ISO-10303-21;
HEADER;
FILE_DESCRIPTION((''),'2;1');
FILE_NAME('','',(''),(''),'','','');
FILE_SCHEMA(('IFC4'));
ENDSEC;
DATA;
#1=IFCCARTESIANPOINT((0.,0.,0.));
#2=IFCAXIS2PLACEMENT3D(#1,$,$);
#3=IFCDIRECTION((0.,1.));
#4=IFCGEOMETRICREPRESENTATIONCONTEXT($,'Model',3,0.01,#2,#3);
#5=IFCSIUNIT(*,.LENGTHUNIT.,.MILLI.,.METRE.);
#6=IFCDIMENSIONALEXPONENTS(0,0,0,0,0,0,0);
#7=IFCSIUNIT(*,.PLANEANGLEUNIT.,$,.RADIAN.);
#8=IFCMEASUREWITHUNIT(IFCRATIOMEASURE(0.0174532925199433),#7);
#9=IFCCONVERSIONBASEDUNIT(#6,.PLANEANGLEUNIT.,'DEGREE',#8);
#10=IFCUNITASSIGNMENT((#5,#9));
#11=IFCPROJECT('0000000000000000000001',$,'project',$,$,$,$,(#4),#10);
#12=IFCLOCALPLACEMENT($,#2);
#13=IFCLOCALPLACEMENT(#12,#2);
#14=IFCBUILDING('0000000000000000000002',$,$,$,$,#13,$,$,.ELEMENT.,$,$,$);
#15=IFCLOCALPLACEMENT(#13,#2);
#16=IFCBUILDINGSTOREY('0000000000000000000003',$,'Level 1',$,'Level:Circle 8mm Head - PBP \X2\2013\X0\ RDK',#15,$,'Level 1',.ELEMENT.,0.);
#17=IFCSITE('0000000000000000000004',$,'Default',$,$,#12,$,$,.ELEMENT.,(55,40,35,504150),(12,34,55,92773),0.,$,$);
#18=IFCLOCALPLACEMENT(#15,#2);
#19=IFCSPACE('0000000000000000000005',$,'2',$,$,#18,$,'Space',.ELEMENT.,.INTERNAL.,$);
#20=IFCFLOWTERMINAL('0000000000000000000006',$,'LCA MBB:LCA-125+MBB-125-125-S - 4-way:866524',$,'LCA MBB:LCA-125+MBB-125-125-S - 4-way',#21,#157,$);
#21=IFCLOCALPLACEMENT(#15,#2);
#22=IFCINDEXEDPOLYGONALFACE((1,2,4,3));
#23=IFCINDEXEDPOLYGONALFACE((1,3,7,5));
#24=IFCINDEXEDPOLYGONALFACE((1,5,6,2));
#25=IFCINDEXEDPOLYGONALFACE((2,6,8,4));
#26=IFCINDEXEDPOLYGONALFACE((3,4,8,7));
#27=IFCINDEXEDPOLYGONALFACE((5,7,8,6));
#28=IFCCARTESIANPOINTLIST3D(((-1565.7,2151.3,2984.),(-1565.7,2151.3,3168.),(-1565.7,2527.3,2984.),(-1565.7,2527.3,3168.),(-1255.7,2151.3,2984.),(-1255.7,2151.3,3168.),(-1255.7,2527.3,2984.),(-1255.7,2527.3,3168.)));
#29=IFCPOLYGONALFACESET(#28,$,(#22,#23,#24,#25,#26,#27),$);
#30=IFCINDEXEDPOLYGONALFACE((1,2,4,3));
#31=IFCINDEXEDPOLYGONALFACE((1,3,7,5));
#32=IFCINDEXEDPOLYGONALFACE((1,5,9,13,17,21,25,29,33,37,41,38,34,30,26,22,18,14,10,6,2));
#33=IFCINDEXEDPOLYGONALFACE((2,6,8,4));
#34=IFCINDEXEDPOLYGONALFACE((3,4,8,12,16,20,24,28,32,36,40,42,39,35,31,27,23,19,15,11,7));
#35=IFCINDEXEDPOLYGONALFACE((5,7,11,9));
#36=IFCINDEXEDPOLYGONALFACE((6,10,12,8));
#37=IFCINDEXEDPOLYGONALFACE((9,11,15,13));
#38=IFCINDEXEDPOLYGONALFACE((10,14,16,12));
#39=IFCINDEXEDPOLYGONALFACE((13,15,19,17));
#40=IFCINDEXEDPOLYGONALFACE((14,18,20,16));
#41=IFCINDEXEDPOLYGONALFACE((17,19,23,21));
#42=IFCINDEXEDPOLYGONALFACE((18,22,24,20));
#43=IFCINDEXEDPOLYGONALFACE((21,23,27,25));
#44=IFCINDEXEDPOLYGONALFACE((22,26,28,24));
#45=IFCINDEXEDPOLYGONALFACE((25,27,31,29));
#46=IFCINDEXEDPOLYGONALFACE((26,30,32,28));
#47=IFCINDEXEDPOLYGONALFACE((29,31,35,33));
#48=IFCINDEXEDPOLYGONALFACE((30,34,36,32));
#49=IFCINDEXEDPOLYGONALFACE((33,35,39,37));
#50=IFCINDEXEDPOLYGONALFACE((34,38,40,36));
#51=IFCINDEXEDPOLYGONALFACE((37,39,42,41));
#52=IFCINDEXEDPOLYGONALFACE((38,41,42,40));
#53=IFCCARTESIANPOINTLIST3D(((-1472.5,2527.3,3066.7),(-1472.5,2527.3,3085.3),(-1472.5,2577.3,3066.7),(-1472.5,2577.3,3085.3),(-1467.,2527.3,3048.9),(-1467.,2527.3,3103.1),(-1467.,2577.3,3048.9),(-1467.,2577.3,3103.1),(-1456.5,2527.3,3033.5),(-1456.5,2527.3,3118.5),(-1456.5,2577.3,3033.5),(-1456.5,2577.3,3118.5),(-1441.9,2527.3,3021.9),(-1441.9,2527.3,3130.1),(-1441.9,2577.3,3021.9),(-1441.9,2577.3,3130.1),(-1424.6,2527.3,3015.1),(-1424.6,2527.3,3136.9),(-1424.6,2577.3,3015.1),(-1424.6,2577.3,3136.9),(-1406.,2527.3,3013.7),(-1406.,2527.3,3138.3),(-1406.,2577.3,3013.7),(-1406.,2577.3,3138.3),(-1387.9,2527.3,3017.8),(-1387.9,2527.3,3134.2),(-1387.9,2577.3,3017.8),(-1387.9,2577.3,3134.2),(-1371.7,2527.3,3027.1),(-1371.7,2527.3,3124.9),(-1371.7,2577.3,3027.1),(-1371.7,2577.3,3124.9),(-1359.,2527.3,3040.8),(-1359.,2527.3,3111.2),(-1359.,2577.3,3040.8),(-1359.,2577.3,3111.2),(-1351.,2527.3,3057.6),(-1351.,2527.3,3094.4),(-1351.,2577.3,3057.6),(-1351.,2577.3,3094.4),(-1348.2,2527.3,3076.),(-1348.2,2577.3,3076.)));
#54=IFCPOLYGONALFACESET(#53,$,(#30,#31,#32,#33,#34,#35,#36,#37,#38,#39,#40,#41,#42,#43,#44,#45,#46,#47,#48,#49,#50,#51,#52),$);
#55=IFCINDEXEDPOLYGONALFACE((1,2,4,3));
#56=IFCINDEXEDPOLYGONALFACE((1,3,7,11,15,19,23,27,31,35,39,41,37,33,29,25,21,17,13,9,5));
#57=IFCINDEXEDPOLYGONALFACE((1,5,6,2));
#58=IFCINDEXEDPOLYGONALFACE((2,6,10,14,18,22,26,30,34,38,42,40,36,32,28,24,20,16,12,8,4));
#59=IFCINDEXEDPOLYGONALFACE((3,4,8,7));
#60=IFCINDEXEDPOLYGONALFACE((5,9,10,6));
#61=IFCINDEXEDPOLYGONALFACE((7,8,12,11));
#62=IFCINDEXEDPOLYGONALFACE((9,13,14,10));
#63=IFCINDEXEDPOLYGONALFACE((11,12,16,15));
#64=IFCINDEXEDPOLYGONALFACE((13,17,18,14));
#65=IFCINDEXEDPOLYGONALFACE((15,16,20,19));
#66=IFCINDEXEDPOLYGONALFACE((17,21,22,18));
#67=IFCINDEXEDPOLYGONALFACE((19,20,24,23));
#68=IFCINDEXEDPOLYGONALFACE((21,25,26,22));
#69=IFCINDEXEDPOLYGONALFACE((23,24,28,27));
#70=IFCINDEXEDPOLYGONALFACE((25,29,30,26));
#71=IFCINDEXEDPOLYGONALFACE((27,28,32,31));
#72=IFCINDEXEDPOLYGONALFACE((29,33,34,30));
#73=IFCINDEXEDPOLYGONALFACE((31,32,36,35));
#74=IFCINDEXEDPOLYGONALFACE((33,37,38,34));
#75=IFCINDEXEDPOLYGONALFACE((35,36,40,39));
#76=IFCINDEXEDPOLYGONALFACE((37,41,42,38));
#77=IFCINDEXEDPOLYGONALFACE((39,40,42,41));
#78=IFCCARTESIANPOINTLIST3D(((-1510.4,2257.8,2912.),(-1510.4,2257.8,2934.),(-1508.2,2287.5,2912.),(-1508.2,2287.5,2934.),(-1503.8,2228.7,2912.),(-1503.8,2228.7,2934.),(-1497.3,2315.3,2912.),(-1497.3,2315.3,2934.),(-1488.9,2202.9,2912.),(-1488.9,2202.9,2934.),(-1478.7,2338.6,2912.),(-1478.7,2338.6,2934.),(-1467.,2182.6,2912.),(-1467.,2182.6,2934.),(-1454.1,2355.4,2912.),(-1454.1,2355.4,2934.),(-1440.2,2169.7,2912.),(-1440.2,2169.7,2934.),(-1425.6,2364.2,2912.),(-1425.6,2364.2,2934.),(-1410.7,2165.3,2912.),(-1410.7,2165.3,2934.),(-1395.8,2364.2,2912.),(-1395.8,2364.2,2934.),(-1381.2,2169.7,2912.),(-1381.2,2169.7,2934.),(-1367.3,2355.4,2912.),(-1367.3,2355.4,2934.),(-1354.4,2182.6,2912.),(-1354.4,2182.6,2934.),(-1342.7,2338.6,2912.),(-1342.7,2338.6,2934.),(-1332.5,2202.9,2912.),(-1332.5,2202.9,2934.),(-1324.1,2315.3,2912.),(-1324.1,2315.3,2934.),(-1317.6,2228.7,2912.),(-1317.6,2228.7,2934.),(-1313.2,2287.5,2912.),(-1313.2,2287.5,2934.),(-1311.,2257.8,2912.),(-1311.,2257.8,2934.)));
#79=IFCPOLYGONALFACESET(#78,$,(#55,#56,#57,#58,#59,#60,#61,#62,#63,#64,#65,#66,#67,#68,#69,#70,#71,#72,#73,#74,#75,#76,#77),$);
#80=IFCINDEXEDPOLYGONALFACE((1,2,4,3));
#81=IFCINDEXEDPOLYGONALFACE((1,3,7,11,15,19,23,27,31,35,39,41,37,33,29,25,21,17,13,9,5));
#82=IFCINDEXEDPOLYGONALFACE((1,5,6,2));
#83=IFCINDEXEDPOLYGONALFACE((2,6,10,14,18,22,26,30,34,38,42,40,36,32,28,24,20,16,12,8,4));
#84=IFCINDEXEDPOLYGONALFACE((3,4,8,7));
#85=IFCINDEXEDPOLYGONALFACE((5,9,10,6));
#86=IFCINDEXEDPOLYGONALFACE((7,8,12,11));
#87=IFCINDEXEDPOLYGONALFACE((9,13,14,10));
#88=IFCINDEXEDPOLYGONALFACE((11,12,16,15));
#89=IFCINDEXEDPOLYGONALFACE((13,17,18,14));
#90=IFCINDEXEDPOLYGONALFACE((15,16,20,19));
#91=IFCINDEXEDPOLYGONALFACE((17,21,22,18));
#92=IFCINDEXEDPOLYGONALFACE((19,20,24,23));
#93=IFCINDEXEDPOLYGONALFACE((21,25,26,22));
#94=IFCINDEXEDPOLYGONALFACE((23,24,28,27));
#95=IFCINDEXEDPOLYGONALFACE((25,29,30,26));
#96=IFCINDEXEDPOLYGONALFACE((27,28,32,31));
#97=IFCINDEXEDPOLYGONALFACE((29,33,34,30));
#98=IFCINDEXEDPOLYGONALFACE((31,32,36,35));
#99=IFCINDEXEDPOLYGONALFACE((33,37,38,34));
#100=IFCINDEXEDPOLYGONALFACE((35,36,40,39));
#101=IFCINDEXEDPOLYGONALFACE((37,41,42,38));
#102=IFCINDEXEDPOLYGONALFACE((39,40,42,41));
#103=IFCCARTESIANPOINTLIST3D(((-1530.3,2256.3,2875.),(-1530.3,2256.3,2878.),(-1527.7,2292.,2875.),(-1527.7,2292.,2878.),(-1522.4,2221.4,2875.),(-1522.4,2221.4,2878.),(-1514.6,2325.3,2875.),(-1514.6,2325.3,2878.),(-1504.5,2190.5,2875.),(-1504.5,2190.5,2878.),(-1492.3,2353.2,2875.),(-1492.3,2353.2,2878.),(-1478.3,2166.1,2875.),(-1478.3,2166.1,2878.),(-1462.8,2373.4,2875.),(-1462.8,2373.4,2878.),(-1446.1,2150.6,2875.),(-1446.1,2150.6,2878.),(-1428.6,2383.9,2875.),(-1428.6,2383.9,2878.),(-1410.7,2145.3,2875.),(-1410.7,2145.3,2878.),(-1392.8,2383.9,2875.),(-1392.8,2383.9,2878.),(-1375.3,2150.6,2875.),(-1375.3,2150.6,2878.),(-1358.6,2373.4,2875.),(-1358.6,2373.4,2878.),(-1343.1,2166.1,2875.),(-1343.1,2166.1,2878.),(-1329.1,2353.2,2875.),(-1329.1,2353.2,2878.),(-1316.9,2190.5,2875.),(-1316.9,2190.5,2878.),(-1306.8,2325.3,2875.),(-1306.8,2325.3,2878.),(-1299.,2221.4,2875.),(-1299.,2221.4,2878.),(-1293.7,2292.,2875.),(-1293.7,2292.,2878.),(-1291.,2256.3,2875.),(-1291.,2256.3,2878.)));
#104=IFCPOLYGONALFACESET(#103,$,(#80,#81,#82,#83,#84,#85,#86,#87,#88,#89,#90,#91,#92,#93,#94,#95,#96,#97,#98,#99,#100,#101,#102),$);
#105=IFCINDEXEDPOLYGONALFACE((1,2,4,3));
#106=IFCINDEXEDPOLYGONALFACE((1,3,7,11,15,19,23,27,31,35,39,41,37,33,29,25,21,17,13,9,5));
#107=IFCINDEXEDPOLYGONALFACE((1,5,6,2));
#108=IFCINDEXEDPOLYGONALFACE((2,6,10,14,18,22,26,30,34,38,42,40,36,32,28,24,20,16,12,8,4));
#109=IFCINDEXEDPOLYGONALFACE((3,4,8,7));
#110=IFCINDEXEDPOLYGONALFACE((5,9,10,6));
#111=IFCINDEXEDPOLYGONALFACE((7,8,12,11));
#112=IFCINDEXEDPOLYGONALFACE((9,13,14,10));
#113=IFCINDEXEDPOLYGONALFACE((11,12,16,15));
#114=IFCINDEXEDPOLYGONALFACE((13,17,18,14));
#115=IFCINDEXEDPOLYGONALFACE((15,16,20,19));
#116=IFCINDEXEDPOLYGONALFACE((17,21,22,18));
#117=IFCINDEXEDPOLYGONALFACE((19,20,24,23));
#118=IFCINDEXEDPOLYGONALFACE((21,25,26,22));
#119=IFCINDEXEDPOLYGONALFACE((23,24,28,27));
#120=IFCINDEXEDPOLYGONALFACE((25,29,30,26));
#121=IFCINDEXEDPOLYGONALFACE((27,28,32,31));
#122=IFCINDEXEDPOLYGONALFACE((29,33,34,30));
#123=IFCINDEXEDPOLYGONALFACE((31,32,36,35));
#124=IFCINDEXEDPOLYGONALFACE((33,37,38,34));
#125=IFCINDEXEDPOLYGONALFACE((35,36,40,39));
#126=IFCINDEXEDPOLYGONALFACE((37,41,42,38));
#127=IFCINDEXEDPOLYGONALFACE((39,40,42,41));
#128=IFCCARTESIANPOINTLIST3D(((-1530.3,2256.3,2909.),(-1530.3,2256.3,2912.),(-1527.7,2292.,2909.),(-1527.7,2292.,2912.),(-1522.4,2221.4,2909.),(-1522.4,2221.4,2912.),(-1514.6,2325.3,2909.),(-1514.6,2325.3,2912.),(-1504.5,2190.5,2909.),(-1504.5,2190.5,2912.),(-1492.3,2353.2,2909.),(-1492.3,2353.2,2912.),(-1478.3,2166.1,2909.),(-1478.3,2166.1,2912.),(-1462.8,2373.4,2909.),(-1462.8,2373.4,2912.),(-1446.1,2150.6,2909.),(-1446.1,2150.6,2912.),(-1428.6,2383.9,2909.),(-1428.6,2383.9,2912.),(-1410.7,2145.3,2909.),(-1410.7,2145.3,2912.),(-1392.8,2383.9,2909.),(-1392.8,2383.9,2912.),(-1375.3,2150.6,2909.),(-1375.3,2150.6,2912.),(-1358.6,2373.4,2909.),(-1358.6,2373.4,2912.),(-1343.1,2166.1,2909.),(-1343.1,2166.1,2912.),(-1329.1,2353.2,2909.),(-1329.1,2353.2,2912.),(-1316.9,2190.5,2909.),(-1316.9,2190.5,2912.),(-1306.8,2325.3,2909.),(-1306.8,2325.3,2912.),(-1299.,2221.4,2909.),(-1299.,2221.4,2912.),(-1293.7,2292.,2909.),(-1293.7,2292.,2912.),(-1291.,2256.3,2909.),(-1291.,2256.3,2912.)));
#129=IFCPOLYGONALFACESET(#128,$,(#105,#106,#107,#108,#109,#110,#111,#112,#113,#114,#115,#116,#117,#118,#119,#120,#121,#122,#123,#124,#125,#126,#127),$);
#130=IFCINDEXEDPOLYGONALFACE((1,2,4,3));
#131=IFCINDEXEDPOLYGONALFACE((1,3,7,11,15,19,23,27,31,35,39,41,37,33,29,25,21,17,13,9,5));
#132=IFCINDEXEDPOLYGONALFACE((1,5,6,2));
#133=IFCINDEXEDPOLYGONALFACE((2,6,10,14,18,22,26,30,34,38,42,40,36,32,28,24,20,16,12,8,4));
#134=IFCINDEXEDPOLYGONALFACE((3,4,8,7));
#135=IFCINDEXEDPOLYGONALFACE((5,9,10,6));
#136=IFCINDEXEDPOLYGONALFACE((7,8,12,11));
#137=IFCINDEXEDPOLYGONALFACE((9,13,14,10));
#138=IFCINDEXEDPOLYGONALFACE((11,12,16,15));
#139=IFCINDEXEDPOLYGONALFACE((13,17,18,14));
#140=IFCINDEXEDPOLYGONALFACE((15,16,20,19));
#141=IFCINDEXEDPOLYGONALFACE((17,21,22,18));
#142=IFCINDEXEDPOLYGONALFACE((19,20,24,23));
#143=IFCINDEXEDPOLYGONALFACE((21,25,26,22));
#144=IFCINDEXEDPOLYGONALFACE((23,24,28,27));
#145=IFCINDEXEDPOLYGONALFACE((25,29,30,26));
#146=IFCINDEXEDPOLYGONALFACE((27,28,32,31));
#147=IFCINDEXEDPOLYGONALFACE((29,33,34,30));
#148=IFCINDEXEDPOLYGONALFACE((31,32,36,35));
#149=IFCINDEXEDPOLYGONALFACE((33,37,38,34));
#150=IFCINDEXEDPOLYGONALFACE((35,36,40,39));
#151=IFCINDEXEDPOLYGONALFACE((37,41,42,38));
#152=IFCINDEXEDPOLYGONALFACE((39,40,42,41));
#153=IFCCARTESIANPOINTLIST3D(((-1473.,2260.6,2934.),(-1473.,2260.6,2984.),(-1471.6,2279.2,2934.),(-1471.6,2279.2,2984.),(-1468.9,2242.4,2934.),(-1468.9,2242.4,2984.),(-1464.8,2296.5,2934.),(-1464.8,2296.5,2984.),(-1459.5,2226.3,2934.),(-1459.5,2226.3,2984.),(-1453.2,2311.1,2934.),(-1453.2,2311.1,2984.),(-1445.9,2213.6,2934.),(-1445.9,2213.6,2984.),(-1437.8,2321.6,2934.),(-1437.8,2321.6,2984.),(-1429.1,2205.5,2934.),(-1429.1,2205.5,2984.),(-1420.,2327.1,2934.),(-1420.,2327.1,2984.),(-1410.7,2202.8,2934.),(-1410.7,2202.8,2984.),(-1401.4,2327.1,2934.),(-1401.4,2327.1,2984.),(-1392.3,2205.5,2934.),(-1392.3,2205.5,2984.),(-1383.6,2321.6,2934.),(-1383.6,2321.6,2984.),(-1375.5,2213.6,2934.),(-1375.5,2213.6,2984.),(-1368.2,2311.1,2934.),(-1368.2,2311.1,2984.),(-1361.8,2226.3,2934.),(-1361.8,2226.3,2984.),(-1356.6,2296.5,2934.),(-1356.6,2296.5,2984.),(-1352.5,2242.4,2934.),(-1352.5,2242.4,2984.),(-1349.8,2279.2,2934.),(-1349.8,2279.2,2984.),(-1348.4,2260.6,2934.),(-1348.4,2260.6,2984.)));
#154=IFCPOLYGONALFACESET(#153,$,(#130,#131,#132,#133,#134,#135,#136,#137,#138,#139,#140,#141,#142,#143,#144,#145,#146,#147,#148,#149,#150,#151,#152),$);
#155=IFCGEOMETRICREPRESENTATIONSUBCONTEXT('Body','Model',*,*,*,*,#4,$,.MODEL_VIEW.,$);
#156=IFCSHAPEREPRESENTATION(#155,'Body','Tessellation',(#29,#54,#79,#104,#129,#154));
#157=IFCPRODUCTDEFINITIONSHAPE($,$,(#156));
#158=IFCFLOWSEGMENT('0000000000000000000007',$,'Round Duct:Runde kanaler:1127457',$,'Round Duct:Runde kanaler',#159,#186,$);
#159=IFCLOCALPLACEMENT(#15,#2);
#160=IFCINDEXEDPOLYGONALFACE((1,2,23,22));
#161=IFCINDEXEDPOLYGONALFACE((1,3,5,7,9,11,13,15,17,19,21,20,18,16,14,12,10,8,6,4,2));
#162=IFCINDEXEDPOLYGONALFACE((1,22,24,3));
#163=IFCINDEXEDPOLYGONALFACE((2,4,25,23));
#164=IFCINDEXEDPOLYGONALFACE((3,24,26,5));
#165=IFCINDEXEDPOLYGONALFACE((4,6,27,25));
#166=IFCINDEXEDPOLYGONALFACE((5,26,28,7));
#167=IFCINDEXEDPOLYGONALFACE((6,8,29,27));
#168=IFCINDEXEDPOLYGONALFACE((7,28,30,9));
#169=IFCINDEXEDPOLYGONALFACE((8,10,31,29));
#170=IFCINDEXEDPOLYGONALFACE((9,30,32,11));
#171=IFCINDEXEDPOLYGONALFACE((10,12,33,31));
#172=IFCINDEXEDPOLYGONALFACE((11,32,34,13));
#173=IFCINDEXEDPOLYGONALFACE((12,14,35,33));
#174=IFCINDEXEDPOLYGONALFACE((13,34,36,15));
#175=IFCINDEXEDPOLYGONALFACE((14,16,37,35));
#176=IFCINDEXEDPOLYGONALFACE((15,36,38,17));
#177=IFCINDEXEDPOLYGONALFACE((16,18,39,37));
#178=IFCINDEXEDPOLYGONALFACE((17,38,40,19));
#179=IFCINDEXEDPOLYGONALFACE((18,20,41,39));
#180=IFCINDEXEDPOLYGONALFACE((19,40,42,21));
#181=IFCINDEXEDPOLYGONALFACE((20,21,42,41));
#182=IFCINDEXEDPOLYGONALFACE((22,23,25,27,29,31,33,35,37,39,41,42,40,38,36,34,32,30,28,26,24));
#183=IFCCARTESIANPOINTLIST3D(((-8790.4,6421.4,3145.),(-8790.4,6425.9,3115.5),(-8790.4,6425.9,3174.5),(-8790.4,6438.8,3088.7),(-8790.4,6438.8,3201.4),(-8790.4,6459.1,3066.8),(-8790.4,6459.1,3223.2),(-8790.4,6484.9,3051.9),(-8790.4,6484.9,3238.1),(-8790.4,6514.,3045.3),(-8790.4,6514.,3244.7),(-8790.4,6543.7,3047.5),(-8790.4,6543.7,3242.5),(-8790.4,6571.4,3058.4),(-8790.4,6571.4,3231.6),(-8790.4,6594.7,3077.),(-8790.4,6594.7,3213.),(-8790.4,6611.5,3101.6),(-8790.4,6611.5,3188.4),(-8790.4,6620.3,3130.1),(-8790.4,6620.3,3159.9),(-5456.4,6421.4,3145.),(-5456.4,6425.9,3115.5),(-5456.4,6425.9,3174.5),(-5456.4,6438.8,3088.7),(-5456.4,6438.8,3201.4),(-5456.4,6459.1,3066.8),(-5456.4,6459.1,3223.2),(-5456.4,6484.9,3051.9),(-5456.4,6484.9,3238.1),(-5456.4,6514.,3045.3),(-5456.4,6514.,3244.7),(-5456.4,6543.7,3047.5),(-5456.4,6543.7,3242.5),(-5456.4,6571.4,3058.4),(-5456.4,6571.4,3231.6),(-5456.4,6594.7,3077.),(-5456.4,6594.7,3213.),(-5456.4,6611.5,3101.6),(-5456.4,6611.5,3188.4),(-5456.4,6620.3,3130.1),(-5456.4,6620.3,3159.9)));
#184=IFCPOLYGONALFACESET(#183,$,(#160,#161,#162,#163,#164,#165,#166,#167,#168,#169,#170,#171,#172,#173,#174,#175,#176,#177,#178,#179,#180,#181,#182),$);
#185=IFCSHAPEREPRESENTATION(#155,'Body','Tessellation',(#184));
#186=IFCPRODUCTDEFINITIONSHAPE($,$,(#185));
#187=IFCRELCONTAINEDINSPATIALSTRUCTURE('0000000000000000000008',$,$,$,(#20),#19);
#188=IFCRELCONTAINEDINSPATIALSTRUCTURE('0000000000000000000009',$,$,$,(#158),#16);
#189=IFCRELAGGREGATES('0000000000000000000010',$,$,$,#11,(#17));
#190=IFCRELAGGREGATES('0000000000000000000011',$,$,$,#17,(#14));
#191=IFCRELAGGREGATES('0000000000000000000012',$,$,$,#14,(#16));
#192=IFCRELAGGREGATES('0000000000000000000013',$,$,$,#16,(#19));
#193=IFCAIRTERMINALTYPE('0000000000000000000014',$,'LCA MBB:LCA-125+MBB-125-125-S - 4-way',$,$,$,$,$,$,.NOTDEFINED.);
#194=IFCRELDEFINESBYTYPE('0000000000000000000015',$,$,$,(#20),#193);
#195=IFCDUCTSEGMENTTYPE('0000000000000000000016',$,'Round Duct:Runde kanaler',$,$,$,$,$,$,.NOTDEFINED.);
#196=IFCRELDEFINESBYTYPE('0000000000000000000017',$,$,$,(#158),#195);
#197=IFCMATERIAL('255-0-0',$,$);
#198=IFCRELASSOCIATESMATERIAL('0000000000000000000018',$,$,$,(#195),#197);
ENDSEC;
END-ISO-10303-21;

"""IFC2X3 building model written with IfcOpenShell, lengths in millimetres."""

from ifc_helpers import new_model, entity, si_unit, converted_unit, direction, frame, frame_2d, origin, origin_2d_with_axis, place, context, subcontext, project, spatial, rectangle, circle, extrude, source, transform, mapped, material, type_object, type_shapes, element, save


model = new_model("IFC2X3")

# Units and contexts
model_context = context("Model", 3, precision=0.01, world=origin(), true_north=direction((0.0, 1.0)))
body_context = subcontext(model_context, "Body", "Model", "MODEL_VIEW")
ifc_project = project(units=[si_unit("LENGTHUNIT", "METRE", prefix="MILLI"), converted_unit("PLANEANGLEUNIT", "DEGREE", entity("IfcRatioMeasure", 0.0174532925199433), si_unit("PLANEANGLEUNIT", "RADIAN"), dimensions=[0, 0, 0, 0, 0, 0, 0])], contexts=[model_context])

# Site, building, storey
site_placement = place(None, origin())
site = spatial("IfcSite", under=ifc_project, at=site_placement, Name="Default", CompositionType="ELEMENT", RefLatitude=(55, 40, 35, 504150), RefLongitude=(12, 34, 55, 92773), RefElevation=0.0)
building_placement = place(site_placement, origin())
building = spatial("IfcBuilding", under=site, at=building_placement, CompositionType="ELEMENT")
storey_placement = place(building_placement, origin())
storey = spatial("IfcBuildingStorey", under=building, at=storey_placement, Name="Level 1", ObjectType="Level:Circle 8mm Head - PBP – RDK", LongName="Level 1", CompositionType="ELEMENT", Elevation=0.0)

# Shared definitions
air_terminal_type_1 = type_object("IfcAirTerminalType", Name="LCA MBB:LCA-125+MBB-125-125-S - 4-way", PredefinedType="NOTDEFINED")
shared_shape_1 = source(origin(), body_context, "Body", "SweptSolid", [
    extrude(rectangle(XDim=310.0, YDim=376.0, at=origin_2d_with_axis()), frame((-74.0, 0.0, 72.0), z_axis=(0.0, 0.0, 1.0), x_axis=(0.0, -1.0, 0.0)), (0.0, 0.0, 1.0), 184.0),
    extrude(circle(Radius=62.5, at=frame_2d((0.0, 0.0), x_axis=(1.0, 0.0))), frame((-312.0, 0.0, 164.0), z_axis=(1.0, 0.0, 0.0), x_axis=(0.0, 1.0, 0.0)), (0.0, 0.0, 1.0), 50.0),
    extrude(circle(Radius=100.0, at=frame_2d((0.0, 0.0), x_axis=(1.0, 0.0))), origin(), (0.0, 0.0, 1.0), 22.0),
    extrude(circle(Radius=120.0, at=frame_2d((0.0, 0.0), x_axis=(1.0, 0.0))), frame((0.0, 0.0, -37.0)), (0.0, 0.0, 1.0), 3.0),
    extrude(circle(Radius=120.0, at=frame_2d((0.0, 0.0), x_axis=(1.0, 0.0))), frame((0.0, 0.0, -3.0)), (0.0, 0.0, 1.0), 3.0),
    extrude(circle(Radius=62.5, at=frame_2d((0.0, 0.0), x_axis=(1.0, 0.0))), frame((0.0, 0.0, 22.0)), (0.0, 0.0, 1.0), 50.0),
])
type_shapes(air_terminal_type_1, [shared_shape_1])

# Shared definitions
space_1_placement = place(storey_placement, origin())
space_1 = spatial("IfcSpace", under=storey, at=space_1_placement, Name="2", LongName="Space", CompositionType="ELEMENT", InteriorOrExteriorSpace="INTERNAL")

# Flow terminal
flow_terminal_1_placement = place(space_1_placement, frame((-1410.7, 2265.3, 2912.0), z_axis=(0.0, 0.0, 1.0), x_axis=(0.0, -1.0, 0.0)))
element("IfcFlowTerminal", 1, at=flow_terminal_1_placement, inside=space_1, type_object=air_terminal_type_1, Name="LCA MBB:LCA-125+MBB-125-125-S - 4-way:866524", ObjectType="LCA MBB:LCA-125+MBB-125-125-S - 4-way", context=body_context, shape_type="MappedRepresentation", body=[
    mapped(shared_shape_1, transform((0.0, 0.0, 0.0), scale=1.0)),
])

# Flow segment
ifc_material_1 = material(Name="255-0-0")
duct_segment_type = type_object("IfcDuctSegmentType", Name="Round Duct:Runde kanaler", PredefinedType="NOTDEFINED", material=ifc_material_1)
flow_segment_1_placement = place(storey_placement, origin())
element("IfcFlowSegment", 2, at=flow_segment_1_placement, inside=storey, type_object=duct_segment_type, Name="Round Duct:Runde kanaler:1127457", ObjectType="Round Duct:Runde kanaler", context=body_context, shape_type="SweptSolid", body=[
    extrude(circle(Radius=100.0, at=origin_2d_with_axis()), frame((-8790.4, 6521.4, 3145.0), z_axis=(1.0, 0.0, 0.0), x_axis=(0.0, -1.0, 0.0)), (0.0, 0.0, 1.0), 3334.0),
])

save(model, "model.ifc")
